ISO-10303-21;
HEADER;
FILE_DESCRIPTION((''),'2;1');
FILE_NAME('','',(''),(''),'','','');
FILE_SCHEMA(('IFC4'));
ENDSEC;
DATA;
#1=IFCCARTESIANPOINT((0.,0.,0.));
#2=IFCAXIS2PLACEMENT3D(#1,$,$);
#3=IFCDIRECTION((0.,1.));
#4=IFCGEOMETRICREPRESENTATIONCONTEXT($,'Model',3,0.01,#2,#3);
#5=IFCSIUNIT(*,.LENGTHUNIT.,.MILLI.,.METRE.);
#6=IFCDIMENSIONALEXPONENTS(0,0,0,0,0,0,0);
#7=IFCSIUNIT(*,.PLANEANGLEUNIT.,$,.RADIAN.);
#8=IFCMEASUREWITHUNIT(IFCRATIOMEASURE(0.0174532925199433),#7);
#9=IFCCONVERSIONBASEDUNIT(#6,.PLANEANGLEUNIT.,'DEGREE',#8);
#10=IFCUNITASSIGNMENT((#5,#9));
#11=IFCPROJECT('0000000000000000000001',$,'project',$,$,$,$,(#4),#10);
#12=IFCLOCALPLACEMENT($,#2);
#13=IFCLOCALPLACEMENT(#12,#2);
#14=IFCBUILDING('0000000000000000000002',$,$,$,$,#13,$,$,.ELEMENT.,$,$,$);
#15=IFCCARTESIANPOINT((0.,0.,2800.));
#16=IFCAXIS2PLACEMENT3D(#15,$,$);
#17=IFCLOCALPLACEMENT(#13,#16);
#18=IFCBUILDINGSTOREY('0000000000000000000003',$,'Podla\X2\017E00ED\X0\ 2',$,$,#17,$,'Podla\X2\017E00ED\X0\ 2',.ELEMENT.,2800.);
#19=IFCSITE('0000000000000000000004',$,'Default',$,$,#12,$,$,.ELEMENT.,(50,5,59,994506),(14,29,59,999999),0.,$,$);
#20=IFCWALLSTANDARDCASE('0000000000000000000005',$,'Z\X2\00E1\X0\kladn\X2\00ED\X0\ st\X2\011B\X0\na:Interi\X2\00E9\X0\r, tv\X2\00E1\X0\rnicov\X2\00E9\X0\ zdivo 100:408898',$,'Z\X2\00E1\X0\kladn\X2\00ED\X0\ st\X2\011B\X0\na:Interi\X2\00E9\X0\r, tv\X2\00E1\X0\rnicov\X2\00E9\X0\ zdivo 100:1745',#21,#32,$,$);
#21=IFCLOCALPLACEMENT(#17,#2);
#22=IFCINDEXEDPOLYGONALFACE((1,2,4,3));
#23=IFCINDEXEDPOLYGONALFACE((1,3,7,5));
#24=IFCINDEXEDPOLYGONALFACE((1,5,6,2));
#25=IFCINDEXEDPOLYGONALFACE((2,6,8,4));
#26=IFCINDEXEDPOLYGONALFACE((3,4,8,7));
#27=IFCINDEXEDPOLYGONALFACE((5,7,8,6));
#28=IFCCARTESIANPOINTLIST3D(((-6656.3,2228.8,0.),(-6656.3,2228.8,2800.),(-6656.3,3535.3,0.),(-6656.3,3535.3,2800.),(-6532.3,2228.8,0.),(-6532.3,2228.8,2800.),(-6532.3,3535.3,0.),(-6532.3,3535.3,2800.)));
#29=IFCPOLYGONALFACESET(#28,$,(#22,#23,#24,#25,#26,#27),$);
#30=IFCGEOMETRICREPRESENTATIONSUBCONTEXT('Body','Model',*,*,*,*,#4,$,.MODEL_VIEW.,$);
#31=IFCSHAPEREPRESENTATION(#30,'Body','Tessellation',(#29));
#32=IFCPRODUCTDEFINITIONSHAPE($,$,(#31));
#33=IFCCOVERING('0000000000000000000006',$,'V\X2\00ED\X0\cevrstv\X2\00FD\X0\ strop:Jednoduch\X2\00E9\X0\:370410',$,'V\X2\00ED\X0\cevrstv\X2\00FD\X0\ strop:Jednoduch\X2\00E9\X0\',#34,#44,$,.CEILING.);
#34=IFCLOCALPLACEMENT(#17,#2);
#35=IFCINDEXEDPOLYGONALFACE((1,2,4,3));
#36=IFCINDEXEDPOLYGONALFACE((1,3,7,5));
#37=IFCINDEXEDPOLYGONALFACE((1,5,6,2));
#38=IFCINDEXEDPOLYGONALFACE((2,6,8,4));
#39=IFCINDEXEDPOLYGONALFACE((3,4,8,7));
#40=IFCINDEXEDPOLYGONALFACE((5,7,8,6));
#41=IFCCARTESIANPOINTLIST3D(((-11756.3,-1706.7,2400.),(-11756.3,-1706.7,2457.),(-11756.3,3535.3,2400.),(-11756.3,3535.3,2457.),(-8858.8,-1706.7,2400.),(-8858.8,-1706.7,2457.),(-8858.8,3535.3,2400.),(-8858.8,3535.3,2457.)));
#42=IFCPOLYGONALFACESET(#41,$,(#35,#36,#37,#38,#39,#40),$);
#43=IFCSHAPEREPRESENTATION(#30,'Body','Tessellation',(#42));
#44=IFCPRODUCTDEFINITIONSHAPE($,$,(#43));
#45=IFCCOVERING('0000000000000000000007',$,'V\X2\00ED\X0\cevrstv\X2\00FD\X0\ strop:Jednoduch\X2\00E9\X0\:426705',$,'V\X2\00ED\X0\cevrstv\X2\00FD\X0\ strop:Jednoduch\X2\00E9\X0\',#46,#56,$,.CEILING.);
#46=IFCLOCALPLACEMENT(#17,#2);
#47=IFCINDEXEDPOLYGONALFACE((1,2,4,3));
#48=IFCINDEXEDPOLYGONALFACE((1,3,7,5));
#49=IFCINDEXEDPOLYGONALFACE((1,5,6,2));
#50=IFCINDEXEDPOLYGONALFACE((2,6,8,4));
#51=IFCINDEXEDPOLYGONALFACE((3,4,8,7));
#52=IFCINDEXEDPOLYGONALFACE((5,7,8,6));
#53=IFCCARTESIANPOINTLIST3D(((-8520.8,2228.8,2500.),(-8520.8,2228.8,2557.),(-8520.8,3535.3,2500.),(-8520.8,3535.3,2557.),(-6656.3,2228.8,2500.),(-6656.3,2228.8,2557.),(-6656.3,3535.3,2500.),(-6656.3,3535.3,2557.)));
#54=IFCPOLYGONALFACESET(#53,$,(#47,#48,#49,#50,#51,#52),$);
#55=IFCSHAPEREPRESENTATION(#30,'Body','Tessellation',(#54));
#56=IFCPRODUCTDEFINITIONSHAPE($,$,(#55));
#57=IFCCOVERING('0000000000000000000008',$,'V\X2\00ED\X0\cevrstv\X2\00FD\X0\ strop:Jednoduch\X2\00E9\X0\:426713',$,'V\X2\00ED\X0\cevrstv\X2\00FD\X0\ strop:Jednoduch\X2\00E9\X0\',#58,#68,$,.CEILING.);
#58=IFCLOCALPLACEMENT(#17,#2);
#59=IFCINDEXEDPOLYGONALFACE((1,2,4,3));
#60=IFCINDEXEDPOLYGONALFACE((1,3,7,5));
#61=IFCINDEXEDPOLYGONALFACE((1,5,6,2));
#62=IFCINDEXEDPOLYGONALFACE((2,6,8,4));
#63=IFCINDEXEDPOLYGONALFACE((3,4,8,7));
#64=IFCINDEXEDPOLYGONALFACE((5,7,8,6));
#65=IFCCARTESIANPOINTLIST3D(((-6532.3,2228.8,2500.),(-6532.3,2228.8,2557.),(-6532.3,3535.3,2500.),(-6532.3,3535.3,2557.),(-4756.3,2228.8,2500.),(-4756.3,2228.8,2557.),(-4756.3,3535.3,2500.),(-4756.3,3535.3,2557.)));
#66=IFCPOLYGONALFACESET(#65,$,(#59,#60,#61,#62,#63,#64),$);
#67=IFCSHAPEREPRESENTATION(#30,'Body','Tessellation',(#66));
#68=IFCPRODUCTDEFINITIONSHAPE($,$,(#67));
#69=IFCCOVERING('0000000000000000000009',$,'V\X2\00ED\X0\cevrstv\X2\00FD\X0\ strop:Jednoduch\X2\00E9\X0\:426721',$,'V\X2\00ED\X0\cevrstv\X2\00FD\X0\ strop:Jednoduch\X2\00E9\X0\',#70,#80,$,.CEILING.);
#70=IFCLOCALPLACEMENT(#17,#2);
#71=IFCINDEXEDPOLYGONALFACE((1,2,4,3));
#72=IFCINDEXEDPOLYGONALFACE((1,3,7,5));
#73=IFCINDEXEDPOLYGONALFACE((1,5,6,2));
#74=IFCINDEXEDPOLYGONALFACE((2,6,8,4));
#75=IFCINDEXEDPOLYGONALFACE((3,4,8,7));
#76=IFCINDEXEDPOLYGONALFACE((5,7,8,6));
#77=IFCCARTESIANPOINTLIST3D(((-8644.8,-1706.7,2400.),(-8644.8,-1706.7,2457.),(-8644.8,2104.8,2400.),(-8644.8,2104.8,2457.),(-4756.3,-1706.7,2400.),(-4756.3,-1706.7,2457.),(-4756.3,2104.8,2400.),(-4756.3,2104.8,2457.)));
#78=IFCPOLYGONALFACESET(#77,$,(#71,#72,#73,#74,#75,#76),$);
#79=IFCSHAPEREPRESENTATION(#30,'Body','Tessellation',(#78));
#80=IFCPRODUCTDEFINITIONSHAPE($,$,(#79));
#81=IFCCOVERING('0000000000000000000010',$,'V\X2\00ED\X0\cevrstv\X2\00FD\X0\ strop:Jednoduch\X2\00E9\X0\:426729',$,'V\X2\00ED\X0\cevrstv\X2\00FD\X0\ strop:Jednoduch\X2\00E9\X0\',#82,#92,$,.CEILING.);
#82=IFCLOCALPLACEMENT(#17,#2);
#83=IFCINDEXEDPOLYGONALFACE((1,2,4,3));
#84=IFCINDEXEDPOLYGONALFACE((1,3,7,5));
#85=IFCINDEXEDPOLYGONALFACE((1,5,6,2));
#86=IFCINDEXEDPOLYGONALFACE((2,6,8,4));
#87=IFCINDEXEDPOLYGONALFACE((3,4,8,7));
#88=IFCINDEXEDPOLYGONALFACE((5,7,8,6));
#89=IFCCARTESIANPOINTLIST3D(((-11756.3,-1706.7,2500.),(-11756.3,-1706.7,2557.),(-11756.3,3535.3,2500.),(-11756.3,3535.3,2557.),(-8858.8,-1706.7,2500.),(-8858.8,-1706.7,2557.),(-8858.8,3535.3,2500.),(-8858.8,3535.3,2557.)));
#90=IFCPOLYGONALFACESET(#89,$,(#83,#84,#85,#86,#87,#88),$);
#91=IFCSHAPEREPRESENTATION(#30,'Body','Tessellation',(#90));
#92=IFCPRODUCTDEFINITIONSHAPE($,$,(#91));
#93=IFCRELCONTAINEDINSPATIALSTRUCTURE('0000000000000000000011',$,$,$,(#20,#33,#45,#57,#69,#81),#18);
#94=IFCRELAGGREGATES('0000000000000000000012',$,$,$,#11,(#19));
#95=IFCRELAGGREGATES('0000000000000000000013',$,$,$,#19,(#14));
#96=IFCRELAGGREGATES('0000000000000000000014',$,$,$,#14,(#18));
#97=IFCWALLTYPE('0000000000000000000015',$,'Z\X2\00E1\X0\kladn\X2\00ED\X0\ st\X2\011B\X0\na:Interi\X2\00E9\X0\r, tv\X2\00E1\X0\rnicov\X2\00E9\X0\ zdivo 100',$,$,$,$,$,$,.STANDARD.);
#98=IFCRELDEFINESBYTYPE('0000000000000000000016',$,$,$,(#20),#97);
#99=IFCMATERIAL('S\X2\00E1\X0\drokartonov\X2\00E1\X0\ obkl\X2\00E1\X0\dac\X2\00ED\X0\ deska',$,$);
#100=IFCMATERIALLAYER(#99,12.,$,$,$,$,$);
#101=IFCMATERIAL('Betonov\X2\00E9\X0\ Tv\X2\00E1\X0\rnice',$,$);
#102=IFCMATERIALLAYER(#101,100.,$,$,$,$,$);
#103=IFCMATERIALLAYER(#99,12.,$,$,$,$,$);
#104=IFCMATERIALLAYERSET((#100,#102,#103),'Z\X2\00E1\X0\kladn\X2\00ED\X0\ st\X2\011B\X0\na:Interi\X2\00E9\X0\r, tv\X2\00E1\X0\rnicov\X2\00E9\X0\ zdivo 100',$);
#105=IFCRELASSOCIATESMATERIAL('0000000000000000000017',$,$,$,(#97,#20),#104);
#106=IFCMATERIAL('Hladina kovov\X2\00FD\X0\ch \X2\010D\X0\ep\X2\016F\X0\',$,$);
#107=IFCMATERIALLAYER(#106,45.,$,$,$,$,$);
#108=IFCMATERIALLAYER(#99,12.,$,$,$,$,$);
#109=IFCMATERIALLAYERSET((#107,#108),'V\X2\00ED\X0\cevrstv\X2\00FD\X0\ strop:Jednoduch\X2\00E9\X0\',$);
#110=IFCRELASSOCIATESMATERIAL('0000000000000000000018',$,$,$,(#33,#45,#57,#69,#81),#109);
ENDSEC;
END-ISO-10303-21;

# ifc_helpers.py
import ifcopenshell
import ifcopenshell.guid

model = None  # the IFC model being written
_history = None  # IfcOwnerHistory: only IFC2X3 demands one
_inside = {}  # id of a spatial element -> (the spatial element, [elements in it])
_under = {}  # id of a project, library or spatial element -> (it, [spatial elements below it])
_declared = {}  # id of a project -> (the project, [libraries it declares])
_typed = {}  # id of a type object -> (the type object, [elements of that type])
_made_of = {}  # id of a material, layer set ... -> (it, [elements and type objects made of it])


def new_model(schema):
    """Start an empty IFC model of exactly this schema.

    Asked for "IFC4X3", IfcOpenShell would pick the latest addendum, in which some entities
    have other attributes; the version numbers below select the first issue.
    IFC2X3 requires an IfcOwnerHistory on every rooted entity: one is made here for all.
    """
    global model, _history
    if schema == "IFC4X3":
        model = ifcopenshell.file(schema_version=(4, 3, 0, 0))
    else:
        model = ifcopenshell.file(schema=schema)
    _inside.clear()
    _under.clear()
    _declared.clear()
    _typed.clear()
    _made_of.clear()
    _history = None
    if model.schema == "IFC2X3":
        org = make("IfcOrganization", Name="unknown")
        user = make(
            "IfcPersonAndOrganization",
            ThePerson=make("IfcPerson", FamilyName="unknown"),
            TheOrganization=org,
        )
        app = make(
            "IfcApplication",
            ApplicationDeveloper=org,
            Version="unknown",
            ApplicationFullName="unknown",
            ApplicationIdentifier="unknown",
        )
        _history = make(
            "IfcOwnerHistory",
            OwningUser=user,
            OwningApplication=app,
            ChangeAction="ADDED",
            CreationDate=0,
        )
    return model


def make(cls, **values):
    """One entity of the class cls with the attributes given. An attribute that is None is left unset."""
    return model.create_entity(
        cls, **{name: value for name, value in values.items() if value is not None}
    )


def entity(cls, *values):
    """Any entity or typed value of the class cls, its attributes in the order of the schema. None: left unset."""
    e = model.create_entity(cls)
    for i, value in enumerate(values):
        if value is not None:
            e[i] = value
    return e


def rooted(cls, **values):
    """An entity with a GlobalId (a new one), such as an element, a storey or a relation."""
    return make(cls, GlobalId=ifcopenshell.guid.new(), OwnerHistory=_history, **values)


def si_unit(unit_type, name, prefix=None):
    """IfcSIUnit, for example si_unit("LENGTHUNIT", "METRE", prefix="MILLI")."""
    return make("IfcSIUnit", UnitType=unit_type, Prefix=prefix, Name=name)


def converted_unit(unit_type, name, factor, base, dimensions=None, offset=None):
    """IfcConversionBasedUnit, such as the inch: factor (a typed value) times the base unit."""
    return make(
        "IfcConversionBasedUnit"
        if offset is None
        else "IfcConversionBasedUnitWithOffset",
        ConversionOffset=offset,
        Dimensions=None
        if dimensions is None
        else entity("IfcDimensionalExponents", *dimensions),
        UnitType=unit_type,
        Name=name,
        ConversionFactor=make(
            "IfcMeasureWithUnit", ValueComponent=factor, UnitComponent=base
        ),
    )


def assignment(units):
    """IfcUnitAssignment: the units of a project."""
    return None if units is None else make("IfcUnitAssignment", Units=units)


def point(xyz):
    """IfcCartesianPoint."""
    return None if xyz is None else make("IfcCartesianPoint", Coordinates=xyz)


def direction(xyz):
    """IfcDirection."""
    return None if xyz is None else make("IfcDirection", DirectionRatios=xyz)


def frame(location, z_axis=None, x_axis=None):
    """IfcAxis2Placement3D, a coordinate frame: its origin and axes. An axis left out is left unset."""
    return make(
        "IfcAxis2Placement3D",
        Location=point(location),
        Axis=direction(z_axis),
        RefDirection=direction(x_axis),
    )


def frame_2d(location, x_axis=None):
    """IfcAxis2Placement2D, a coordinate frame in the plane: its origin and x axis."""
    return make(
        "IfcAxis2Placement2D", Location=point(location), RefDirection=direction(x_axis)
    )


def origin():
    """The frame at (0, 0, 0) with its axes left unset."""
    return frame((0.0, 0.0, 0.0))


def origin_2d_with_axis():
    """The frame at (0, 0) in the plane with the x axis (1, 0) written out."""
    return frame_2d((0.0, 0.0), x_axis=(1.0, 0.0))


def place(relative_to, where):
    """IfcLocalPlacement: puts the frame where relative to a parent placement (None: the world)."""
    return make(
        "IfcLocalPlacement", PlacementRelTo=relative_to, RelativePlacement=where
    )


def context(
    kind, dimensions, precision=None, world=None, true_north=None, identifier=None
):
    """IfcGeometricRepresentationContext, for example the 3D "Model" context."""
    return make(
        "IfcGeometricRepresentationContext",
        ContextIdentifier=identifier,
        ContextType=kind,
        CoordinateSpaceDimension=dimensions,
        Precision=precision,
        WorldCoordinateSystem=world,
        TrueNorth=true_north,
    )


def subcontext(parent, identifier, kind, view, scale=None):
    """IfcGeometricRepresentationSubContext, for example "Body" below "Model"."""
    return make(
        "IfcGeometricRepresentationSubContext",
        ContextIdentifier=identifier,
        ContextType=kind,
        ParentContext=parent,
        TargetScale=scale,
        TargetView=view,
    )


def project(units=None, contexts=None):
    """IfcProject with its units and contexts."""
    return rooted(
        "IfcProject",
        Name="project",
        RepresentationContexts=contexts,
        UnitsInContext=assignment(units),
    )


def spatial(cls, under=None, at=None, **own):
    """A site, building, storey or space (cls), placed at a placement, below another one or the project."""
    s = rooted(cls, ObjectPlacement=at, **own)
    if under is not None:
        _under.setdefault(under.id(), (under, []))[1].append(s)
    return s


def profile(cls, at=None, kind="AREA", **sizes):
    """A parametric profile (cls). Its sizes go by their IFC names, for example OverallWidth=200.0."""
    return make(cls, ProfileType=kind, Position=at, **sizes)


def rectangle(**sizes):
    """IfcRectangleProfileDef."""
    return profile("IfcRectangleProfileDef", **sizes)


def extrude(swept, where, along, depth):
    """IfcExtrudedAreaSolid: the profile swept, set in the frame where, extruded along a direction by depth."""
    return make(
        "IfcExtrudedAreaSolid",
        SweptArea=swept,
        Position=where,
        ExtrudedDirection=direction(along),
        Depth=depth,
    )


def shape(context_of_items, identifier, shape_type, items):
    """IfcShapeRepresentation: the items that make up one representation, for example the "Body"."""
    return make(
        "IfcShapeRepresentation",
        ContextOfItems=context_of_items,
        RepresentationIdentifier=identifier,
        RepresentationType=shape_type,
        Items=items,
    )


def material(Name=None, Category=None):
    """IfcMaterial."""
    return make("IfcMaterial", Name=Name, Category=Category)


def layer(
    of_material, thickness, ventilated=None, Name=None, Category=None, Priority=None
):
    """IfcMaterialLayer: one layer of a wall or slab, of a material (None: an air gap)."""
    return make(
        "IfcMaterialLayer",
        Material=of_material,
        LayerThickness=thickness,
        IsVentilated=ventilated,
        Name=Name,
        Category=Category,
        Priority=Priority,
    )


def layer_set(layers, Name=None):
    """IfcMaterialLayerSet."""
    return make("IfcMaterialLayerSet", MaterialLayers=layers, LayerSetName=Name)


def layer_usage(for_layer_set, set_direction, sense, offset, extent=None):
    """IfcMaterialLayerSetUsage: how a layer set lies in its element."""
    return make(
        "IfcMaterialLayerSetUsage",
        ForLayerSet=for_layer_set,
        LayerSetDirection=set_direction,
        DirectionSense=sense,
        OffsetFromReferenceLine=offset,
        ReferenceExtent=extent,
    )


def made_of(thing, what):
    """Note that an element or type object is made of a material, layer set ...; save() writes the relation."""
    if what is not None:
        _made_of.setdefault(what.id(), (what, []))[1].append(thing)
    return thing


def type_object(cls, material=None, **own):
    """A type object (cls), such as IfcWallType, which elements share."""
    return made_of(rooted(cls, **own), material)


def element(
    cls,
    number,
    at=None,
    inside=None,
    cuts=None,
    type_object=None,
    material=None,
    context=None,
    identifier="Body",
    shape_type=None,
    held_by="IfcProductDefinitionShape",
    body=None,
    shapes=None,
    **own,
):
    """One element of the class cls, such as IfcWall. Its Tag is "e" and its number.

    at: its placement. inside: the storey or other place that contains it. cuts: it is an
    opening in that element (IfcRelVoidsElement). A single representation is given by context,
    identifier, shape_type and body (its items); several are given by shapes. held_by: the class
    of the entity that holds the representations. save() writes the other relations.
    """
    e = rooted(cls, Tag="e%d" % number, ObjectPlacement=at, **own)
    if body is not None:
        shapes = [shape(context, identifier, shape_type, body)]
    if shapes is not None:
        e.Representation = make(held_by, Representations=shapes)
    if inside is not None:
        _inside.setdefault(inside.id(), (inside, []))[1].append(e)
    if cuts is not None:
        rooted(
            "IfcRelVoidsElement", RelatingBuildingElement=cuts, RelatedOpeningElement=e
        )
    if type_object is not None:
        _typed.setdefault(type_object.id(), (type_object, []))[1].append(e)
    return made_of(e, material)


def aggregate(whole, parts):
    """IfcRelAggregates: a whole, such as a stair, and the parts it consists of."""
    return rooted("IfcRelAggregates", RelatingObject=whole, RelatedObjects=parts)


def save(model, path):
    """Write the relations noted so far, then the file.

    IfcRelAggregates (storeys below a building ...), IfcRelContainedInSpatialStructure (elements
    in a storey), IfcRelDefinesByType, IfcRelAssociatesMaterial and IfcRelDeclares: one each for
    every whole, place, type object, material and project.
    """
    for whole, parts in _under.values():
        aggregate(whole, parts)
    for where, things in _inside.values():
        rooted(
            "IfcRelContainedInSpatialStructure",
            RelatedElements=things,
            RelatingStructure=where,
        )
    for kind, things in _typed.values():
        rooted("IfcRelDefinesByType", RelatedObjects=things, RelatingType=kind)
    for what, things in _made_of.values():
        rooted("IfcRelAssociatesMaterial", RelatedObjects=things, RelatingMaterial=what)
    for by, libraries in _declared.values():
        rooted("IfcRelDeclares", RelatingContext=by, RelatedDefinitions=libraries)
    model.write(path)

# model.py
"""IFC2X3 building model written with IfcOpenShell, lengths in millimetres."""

from ifc_helpers import new_model, entity, si_unit, converted_unit, direction, frame, frame_2d, origin, origin_2d_with_axis, place, context, subcontext, project, spatial, rectangle, extrude, material, layer, layer_set, layer_usage, type_object, element, save


model = new_model("IFC2X3")

# Units and contexts
model_context = context("Model", 3, precision=0.01, world=origin(), true_north=direction((0.0, 1.0)))
body_context = subcontext(model_context, "Body", "Model", "MODEL_VIEW")
ifc_project = project(units=[si_unit("LENGTHUNIT", "METRE", prefix="MILLI"), converted_unit("PLANEANGLEUNIT", "DEGREE", entity("IfcRatioMeasure", 0.0174532925199433), si_unit("PLANEANGLEUNIT", "RADIAN"), dimensions=[0, 0, 0, 0, 0, 0, 0])], contexts=[model_context])

# Site, building, storey
site_placement = place(None, origin())
site = spatial("IfcSite", under=ifc_project, at=site_placement, Name="Default", CompositionType="ELEMENT", RefLatitude=(50, 5, 59, 994506), RefLongitude=(14, 29, 59, 999999), RefElevation=0.0)
building_placement = place(site_placement, origin())
building = spatial("IfcBuilding", under=site, at=building_placement, CompositionType="ELEMENT")
storey_placement = place(building_placement, frame((0.0, 0.0, 2800.0)))
storey = spatial("IfcBuildingStorey", under=building, at=storey_placement, Name="Podlaží 2", LongName="Podlaží 2", CompositionType="ELEMENT", Elevation=2800.0)

# Shared definitions
ifc_material_1 = material(Name="Betonové Tvárnice")
ifc_material_2 = material(Name="Sádrokartonová obkládací deska")

# Shared definitions
ifc_layer_1 = layer(ifc_material_2, 12.0)
ifc_layer_2 = layer(ifc_material_1, 100.0)
ifc_layer_3 = layer(ifc_material_2, 12.0)
ifc_layer_set_1 = layer_set([ifc_layer_1, ifc_layer_2, ifc_layer_3], Name="Základní stěna:Interiér, tvárnicové zdivo 100")
wall_type_1 = type_object("IfcWallType", Name="Základní stěna:Interiér, tvárnicové zdivo 100", PredefinedType="STANDARD", material=ifc_layer_set_1)

# Wall
ifc_layer_usage_1 = layer_usage(ifc_layer_set_1, "AXIS2", "NEGATIVE", 62.0)
wall_1_placement = place(storey_placement, frame((-6594.3, 2228.8, 0.0), z_axis=(0.0, 0.0, 1.0), x_axis=(0.0, 1.0, 0.0)))
element("IfcWallStandardCase", 1, at=wall_1_placement, inside=storey, type_object=wall_type_1, material=ifc_layer_usage_1, Name="Základní stěna:Interiér, tvárnicové zdivo 100:408898", ObjectType="Základní stěna:Interiér, tvárnicové zdivo 100:1745", context=body_context, shape_type="SweptSolid", body=[
    extrude(rectangle(XDim=1306.5, YDim=124.0, at=frame_2d((653.3, 0.0), x_axis=(-1.0, 0.0))), origin(), (0.0, 0.0, 1.0), 2800.0),
])

# Coverings
ifc_material_3 = material(Name="Hladina kovových čepů")
ifc_layer_4 = layer(ifc_material_3, 45.0)
ifc_layer_5 = layer(ifc_material_2, 12.0)
ifc_layer_set_2 = layer_set([ifc_layer_4, ifc_layer_5], Name="Vícevrstvý strop:Jednoduché")
ifc_layer_usage_2 = layer_usage(ifc_layer_set_2, "AXIS3", "NEGATIVE", 0.0)
covering_1_placement = place(storey_placement, origin())
element("IfcCovering", 2, at=covering_1_placement, inside=storey, material=ifc_layer_usage_2, Name="Vícevrstvý strop:Jednoduché:370410", ObjectType="Vícevrstvý strop:Jednoduché", PredefinedType="CEILING", context=body_context, shape_type="SweptSolid", body=[
    extrude(rectangle(XDim=5242.0, YDim=2897.5, at=frame_2d((0.0, 0.0), x_axis=(1.0, 0.0))), frame((-10307.5, 914.3, 2400.0), z_axis=(0.0, 0.0, 1.0), x_axis=(0.0, 1.0, 0.0)), (0.0, 0.0, 1.0), 57.0),
])
ifc_layer_usage_3 = layer_usage(ifc_layer_set_2, "AXIS3", "NEGATIVE", 0.0)
covering_2_placement = place(storey_placement, origin())
element("IfcCovering", 3, at=covering_2_placement, inside=storey, material=ifc_layer_usage_3, Name="Vícevrstvý strop:Jednoduché:426705", ObjectType="Vícevrstvý strop:Jednoduché", PredefinedType="CEILING", context=body_context, shape_type="SweptSolid", body=[
    extrude(rectangle(XDim=1864.5, YDim=1306.5, at=frame_2d((0.0, 0.0), x_axis=(1.0, 0.0))), frame((-7588.5, 2882.1, 2500.0)), (0.0, 0.0, 1.0), 57.0),
])
ifc_layer_usage_4 = layer_usage(ifc_layer_set_2, "AXIS3", "NEGATIVE", 0.0)
covering_3_placement = place(storey_placement, origin())
element("IfcCovering", 4, at=covering_3_placement, inside=storey, material=ifc_layer_usage_4, Name="Vícevrstvý strop:Jednoduché:426713", ObjectType="Vícevrstvý strop:Jednoduché", PredefinedType="CEILING", context=body_context, shape_type="SweptSolid", body=[
    extrude(rectangle(XDim=1306.5, YDim=1776.0, at=origin_2d_with_axis()), frame((-5644.3, 2882.1, 2500.0), z_axis=(0.0, 0.0, 1.0), x_axis=(0.0, -1.0, 0.0)), (0.0, 0.0, 1.0), 57.0),
])
ifc_layer_usage_5 = layer_usage(ifc_layer_set_2, "AXIS3", "NEGATIVE", 0.0)
covering_4_placement = place(storey_placement, origin())
element("IfcCovering", 5, at=covering_4_placement, inside=storey, material=ifc_layer_usage_5, Name="Vícevrstvý strop:Jednoduché:426721", ObjectType="Vícevrstvý strop:Jednoduché", PredefinedType="CEILING", context=body_context, shape_type="SweptSolid", body=[
    extrude(rectangle(XDim=3888.5, YDim=3811.5, at=frame_2d((0.0, 0.0), x_axis=(1.0, 0.0))), frame((-6700.5, 199.1, 2400.0), z_axis=(0.0, 0.0, 1.0), x_axis=(-1.0, 0.0, 0.0)), (0.0, 0.0, 1.0), 57.0),
])
ifc_layer_usage_6 = layer_usage(ifc_layer_set_2, "AXIS3", "NEGATIVE", 0.0)
covering_5_placement = place(storey_placement, origin())
element("IfcCovering", 6, at=covering_5_placement, inside=storey, material=ifc_layer_usage_6, Name="Vícevrstvý strop:Jednoduché:426729", ObjectType="Vícevrstvý strop:Jednoduché", PredefinedType="CEILING", context=body_context, shape_type="SweptSolid", body=[
    extrude(rectangle(XDim=5242.0, YDim=2897.5, at=frame_2d((0.0, 0.0), x_axis=(1.0, 0.0))), frame((-10307.5, 914.3, 2500.0), z_axis=(0.0, 0.0, 1.0), x_axis=(0.0, 1.0, 0.0)), (0.0, 0.0, 1.0), 57.0),
])

save(model, "model.ifc")
